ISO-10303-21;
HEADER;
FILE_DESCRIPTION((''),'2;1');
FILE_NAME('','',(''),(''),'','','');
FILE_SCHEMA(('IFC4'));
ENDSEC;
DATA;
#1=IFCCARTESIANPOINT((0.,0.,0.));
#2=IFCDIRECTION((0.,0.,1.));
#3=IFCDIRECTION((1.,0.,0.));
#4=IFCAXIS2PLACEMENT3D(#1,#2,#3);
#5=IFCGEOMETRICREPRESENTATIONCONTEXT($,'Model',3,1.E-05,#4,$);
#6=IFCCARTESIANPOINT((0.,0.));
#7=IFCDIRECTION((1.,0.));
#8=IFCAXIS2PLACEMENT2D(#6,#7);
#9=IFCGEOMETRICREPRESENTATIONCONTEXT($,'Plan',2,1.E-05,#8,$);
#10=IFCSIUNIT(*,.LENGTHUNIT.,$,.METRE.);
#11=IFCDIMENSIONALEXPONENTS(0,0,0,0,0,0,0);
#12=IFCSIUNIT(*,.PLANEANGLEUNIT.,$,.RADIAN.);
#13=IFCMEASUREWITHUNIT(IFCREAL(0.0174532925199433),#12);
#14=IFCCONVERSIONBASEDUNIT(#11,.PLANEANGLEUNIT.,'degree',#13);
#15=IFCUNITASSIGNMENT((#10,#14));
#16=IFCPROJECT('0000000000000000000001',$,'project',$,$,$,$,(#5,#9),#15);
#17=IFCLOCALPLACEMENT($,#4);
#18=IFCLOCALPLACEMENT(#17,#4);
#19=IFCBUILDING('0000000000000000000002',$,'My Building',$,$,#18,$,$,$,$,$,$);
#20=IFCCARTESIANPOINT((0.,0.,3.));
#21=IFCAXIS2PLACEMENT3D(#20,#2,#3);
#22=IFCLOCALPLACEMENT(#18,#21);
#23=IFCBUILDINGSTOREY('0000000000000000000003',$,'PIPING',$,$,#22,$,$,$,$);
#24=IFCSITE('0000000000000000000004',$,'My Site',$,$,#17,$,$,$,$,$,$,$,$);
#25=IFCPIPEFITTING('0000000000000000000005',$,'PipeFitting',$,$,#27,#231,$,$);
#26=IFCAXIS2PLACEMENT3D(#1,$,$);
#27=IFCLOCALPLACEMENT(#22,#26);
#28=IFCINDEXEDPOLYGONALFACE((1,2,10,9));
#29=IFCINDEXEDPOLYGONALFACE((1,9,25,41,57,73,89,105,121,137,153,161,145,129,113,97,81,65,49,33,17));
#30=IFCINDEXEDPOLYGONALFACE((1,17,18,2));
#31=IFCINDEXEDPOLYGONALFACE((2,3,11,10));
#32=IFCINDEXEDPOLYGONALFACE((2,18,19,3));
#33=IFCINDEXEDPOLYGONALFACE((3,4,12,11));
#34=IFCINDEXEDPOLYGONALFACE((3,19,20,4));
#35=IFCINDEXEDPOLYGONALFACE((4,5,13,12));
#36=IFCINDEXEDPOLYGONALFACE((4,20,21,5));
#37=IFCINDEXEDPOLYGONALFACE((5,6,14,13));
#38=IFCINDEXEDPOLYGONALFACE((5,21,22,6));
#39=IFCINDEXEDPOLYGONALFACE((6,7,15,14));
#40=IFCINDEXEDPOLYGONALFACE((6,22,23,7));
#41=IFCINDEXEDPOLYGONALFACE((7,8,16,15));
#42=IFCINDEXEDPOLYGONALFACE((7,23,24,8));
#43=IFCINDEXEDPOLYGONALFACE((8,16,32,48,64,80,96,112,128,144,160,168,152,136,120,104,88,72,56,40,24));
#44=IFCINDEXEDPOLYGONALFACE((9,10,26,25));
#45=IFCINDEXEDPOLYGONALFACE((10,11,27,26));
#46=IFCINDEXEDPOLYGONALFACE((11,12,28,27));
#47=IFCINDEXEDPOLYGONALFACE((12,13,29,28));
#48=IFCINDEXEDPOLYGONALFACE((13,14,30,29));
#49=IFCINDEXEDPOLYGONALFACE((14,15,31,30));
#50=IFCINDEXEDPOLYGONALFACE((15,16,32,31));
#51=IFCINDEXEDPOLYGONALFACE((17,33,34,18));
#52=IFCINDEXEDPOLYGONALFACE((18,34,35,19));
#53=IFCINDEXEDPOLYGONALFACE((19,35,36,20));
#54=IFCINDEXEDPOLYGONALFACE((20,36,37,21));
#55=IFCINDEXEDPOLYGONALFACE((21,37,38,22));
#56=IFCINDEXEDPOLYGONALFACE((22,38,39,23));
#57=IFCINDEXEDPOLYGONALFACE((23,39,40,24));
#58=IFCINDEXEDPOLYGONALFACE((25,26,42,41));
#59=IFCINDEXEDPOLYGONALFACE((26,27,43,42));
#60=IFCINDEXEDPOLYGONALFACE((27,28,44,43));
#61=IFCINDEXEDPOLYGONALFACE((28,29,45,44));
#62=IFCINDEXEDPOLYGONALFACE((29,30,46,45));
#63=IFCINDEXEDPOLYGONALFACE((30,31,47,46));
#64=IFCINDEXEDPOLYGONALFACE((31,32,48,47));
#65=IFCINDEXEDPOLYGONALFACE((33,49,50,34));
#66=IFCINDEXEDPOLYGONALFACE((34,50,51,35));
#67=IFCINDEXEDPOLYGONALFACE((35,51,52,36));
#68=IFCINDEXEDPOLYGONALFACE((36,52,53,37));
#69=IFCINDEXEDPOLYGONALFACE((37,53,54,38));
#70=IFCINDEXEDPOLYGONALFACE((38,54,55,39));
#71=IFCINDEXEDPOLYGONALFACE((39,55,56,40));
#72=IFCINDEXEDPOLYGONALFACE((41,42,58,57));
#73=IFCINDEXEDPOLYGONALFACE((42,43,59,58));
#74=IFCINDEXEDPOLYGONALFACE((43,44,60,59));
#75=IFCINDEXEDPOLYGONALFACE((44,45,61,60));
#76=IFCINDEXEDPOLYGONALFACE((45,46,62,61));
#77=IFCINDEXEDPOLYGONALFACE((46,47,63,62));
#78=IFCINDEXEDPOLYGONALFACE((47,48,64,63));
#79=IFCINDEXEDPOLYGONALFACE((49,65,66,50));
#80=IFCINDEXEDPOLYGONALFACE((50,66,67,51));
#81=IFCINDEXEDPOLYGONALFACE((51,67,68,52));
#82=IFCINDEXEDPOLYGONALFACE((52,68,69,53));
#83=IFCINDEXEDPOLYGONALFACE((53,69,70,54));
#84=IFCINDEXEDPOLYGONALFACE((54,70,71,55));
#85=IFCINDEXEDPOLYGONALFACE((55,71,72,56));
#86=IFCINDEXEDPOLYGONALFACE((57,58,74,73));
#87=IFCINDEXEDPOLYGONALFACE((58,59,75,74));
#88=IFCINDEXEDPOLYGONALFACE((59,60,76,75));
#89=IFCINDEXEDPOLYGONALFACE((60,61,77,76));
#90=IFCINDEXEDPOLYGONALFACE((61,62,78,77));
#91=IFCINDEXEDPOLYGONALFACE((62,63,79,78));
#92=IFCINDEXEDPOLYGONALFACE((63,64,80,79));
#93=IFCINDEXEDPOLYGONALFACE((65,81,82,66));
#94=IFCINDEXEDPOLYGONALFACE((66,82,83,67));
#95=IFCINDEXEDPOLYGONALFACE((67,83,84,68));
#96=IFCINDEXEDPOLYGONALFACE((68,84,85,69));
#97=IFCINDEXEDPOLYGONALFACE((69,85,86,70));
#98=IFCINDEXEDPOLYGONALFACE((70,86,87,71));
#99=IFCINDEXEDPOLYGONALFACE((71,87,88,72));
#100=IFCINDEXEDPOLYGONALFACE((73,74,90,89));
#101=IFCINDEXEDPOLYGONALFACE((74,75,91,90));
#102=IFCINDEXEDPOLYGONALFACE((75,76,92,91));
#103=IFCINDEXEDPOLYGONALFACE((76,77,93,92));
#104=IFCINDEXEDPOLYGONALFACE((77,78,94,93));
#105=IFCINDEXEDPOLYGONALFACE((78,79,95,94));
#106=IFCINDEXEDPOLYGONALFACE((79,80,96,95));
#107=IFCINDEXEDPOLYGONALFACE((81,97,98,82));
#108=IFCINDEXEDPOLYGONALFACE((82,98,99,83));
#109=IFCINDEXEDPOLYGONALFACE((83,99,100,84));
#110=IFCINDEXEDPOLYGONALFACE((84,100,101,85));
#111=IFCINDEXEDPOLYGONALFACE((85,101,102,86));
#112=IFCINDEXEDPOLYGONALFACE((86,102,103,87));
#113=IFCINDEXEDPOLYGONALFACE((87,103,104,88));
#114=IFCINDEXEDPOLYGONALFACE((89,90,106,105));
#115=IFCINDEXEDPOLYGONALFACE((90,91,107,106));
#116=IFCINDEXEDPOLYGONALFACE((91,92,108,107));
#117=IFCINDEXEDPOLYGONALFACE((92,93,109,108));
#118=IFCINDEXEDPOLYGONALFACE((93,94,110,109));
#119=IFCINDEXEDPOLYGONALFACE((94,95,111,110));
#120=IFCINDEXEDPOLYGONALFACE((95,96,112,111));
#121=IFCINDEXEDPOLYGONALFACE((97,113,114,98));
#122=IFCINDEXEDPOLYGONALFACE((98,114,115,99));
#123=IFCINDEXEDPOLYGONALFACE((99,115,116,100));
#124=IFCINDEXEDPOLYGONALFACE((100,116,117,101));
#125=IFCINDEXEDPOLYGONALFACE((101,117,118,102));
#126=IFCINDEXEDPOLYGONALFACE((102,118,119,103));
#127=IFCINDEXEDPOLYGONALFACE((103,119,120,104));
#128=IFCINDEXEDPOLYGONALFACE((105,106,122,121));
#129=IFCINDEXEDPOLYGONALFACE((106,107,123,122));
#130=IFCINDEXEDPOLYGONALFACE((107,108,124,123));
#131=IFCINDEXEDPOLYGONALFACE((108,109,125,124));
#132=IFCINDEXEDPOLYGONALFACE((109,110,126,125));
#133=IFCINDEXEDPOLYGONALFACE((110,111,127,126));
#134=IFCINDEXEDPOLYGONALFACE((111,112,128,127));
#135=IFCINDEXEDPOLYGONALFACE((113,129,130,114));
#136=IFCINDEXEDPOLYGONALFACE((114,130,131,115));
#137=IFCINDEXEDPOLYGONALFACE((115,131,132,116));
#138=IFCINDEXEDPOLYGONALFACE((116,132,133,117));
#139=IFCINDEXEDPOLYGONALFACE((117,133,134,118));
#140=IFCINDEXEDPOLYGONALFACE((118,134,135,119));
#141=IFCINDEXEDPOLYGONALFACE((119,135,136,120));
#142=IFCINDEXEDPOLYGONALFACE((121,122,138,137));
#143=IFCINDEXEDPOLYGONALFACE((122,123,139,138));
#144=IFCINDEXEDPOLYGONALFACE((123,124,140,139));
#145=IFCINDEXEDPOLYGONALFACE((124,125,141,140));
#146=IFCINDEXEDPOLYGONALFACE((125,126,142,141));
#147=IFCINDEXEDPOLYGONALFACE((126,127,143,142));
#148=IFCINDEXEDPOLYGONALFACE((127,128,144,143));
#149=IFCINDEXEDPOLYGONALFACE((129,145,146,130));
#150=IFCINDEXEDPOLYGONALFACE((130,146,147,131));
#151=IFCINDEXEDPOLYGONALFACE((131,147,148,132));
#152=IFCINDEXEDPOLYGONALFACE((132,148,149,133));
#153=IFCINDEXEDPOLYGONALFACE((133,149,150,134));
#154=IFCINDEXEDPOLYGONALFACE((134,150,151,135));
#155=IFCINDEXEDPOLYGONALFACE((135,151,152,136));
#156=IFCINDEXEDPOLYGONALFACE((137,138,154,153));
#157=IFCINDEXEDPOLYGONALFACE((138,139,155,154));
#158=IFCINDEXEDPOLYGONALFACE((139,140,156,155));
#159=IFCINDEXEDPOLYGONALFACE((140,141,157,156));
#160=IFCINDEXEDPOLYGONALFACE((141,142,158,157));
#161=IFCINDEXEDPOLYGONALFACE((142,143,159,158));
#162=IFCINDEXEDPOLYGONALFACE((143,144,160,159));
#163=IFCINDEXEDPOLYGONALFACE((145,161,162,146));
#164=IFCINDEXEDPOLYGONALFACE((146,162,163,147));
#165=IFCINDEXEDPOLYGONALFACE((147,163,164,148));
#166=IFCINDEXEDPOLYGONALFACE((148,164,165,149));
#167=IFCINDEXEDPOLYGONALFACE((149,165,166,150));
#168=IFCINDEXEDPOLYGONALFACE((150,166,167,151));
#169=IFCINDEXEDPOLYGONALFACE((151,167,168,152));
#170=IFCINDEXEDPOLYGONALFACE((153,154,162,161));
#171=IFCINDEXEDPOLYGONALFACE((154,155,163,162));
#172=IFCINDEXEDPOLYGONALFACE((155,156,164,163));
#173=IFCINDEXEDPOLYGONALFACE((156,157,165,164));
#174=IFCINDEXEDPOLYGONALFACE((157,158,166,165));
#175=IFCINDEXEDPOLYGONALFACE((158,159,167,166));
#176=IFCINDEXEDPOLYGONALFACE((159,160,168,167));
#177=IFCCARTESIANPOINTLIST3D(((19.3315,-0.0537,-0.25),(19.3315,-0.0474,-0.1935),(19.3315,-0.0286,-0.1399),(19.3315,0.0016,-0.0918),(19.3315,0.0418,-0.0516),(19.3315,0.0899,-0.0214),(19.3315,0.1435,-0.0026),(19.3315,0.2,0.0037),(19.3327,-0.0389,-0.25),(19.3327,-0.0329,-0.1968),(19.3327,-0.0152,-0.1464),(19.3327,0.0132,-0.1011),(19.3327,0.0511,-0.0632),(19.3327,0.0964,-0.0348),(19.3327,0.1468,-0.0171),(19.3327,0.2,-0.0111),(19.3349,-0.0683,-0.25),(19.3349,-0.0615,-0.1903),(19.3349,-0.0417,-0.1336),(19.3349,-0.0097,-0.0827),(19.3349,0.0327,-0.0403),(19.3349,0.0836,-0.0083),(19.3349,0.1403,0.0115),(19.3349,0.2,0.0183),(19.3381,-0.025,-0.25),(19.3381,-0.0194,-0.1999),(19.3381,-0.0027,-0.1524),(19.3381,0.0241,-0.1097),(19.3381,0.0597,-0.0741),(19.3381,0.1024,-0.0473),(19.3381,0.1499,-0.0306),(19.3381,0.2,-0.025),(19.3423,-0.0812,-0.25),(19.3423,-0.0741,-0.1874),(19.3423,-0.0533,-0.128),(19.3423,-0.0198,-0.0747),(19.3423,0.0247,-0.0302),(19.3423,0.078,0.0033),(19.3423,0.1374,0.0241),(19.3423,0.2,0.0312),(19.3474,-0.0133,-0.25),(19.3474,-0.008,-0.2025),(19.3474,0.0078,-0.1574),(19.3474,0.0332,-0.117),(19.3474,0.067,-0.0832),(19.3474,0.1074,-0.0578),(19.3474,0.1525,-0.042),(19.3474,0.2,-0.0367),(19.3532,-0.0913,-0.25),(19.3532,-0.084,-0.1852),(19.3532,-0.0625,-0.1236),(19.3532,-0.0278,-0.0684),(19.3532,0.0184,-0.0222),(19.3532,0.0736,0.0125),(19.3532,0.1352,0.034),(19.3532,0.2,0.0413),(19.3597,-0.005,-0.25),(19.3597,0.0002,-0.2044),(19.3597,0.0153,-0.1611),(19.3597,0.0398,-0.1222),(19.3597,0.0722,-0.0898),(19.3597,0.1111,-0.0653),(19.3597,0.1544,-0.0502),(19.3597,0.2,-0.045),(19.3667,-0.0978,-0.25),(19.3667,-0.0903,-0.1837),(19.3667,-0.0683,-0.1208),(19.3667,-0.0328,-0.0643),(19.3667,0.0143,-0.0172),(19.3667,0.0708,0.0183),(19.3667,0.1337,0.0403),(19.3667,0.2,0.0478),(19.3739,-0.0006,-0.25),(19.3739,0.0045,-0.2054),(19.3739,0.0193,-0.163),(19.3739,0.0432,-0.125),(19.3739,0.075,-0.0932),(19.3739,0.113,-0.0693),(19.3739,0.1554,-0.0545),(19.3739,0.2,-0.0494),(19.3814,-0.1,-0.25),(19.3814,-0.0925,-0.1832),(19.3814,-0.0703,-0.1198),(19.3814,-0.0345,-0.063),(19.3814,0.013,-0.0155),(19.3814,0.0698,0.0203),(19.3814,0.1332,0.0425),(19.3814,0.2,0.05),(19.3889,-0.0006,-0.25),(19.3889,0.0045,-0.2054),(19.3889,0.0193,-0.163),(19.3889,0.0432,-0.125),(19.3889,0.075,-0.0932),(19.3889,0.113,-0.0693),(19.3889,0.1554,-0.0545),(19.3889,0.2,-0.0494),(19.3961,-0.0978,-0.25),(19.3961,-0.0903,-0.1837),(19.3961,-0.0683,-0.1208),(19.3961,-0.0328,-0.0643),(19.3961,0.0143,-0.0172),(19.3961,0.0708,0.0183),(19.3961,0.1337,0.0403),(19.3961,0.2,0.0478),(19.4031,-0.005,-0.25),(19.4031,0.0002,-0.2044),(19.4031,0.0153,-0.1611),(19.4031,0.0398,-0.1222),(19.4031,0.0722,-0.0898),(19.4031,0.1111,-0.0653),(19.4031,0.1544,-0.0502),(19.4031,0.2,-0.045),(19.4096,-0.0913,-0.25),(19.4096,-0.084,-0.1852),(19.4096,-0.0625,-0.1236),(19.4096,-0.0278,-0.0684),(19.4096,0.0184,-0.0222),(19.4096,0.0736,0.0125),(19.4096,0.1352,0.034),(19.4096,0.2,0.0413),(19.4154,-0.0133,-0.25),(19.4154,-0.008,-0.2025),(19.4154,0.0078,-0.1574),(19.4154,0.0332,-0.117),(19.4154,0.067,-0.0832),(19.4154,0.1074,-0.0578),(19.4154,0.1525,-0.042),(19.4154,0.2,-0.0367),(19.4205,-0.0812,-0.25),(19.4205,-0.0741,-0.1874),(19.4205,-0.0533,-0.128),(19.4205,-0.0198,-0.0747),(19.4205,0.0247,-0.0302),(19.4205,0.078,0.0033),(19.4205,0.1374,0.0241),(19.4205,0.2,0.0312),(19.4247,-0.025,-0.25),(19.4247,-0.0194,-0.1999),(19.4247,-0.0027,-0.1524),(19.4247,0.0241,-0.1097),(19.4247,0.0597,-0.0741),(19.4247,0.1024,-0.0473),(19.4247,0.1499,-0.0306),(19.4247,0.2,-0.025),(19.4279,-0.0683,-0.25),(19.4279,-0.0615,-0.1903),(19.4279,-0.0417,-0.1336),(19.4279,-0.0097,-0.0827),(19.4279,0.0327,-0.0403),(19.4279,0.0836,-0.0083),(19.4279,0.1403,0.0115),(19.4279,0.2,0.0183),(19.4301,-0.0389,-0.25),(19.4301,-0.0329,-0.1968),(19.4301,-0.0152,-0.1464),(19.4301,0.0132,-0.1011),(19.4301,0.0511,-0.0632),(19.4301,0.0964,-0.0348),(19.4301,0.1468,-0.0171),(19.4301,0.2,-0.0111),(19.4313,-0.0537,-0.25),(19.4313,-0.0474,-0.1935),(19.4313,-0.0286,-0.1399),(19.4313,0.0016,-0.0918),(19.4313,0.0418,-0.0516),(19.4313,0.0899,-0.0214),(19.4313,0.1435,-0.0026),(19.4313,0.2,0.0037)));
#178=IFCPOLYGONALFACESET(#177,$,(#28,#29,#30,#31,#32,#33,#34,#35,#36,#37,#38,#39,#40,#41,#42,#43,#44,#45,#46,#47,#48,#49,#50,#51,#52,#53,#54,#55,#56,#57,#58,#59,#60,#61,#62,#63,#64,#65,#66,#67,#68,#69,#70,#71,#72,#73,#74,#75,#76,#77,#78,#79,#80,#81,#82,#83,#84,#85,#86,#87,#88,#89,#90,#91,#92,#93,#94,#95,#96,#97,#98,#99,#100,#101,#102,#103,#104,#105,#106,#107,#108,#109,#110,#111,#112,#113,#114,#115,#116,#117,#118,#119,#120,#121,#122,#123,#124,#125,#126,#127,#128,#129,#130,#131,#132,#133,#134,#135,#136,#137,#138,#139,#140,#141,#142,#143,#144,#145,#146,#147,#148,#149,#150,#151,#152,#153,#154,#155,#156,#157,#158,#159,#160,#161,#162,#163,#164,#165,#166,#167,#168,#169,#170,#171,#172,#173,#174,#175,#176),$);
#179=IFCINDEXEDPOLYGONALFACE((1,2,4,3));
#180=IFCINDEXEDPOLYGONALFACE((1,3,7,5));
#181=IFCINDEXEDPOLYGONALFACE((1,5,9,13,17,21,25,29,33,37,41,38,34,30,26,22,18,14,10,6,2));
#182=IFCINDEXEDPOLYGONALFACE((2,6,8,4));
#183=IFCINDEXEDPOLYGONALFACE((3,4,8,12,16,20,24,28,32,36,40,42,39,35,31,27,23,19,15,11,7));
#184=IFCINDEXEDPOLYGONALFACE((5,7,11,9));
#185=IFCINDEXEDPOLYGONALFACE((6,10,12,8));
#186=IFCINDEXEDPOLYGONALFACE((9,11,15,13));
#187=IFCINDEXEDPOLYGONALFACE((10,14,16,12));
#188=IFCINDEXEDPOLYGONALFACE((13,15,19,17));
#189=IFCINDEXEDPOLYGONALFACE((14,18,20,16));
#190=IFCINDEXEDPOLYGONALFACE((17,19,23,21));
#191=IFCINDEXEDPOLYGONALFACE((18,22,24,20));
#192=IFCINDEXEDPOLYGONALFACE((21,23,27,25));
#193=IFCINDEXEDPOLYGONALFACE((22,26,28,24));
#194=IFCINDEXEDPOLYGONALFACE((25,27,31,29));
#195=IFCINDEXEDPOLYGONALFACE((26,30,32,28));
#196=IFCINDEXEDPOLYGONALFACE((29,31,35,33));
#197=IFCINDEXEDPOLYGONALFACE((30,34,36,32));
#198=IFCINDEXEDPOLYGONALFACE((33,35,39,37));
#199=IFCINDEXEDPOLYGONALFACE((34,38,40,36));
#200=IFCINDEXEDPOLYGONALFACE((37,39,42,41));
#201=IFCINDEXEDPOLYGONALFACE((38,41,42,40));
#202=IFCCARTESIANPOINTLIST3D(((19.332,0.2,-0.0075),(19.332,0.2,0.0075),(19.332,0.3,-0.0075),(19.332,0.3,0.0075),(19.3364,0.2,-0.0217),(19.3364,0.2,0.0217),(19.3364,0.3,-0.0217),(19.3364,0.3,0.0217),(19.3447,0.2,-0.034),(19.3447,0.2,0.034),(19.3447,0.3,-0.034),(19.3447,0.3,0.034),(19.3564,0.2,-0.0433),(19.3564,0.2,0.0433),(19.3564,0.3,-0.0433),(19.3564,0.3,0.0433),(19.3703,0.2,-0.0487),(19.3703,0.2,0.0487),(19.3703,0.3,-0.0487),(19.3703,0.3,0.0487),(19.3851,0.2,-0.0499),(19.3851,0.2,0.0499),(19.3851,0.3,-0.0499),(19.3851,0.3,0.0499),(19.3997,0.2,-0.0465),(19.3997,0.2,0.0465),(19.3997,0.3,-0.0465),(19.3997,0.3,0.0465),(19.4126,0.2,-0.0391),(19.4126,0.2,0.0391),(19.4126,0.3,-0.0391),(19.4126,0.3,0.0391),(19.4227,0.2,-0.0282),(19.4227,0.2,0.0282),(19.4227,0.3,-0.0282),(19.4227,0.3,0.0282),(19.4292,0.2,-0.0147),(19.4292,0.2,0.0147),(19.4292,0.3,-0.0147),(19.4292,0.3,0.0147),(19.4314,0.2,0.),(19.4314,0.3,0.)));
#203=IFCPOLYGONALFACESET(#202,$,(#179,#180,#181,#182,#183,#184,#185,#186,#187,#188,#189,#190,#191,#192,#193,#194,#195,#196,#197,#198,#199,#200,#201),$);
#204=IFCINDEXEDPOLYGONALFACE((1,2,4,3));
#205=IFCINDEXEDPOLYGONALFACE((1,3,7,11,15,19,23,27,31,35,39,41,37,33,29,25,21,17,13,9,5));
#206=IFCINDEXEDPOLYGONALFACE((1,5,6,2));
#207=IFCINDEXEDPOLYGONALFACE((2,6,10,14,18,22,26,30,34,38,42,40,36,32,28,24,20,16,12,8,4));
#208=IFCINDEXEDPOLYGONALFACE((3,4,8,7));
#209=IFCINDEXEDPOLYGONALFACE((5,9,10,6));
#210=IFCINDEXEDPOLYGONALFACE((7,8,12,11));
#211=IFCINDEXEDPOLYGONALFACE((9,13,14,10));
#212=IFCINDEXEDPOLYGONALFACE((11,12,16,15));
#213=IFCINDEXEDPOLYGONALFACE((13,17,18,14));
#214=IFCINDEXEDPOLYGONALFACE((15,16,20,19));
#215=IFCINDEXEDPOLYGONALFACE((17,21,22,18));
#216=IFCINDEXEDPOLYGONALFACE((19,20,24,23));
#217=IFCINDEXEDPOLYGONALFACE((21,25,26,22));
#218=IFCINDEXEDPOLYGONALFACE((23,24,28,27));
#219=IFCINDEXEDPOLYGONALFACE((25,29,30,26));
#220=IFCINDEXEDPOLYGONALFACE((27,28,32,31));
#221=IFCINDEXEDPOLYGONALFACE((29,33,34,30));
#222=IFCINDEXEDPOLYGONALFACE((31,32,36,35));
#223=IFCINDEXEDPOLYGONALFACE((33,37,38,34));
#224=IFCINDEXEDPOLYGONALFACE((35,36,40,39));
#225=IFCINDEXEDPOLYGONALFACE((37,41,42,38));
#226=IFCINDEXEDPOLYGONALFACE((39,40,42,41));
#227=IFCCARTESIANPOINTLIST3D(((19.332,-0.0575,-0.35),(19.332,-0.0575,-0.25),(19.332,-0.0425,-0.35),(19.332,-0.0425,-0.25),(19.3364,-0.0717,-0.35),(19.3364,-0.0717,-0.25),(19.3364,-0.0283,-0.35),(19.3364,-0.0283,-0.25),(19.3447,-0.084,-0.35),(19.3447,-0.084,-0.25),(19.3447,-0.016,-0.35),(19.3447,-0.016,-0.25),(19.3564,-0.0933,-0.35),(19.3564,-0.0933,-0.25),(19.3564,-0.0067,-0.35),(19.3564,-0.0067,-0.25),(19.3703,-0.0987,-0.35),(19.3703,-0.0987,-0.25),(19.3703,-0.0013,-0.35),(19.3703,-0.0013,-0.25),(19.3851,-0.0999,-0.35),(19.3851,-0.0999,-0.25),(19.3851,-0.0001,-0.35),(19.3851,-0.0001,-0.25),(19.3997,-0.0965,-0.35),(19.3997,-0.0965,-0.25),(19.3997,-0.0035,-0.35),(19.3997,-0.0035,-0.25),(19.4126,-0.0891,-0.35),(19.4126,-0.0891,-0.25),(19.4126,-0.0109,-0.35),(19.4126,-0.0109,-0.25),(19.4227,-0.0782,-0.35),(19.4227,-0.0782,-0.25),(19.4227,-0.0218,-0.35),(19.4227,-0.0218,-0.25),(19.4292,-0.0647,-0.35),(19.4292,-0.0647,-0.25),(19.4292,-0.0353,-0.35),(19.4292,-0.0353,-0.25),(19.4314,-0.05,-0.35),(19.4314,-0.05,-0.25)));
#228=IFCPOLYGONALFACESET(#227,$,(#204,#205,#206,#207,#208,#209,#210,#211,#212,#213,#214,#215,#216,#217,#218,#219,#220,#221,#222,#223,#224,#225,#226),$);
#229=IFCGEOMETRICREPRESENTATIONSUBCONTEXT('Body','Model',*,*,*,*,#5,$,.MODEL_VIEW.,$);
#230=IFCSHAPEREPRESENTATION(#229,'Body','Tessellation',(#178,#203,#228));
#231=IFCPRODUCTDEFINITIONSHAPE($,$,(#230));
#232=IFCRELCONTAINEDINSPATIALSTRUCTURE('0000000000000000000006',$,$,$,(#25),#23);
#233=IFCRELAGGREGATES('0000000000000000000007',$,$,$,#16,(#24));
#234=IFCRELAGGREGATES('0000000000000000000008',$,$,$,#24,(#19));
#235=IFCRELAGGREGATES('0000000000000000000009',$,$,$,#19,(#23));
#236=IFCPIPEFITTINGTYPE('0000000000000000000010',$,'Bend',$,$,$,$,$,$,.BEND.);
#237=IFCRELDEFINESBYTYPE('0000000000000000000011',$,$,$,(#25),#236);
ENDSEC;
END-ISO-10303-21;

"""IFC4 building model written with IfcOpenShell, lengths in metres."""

from ifc_helpers import new_model, entity, si_unit, converted_unit, frame, origin_with_axes, origin_2d_with_axis, place, context, subcontext, project, spatial, circle, extrude, source, transform, mapped, type_object, type_shapes, element, save


model = new_model("IFC4")

# Units and contexts
model_context = context("Model", 3, precision=1e-05, world=origin_with_axes())
plan_context = context("Plan", 2, precision=1e-05, world=origin_2d_with_axis())
body_context = subcontext(model_context, "Body", "Model", "MODEL_VIEW")
ifc_project = project(units=[si_unit("LENGTHUNIT", "METRE"), converted_unit("PLANEANGLEUNIT", "degree", entity("IfcReal", 0.0174532925199433), si_unit("PLANEANGLEUNIT", "RADIAN"), dimensions=[0, 0, 0, 0, 0, 0, 0])], contexts=[model_context, plan_context])

# Site, building, storey
site_placement = place(None, origin_with_axes())
site = spatial("IfcSite", under=ifc_project, at=site_placement, Name="My Site")
building_placement = place(site_placement, origin_with_axes())
building = spatial("IfcBuilding", under=site, at=building_placement, Name="My Building")
storey_placement = place(building_placement, frame((0.0, 0.0, 3.0), z_axis=(0.0, 0.0, 1.0), x_axis=(1.0, 0.0, 0.0)))
storey = spatial("IfcBuildingStorey", under=building, at=storey_placement, Name="PIPING")

# Shared definitions
pipe_fitting_type = type_object("IfcPipeFittingType", Name="Bend", PredefinedType="BEND")
shared_shape = source(origin_with_axes(), body_context, "Body", "SolidModel", [
    entity("IfcSweptDiskSolid", entity("IfcIndexedPolyCurve", entity("IfcCartesianPointList3D", [[0.0, 0.0, -0.1], [0.0, 0.0732, -0.2768], [0.0, 0.25, -0.35]]), [entity("IfcArcIndex", [1, 2, 3])]), 0.05),
    extrude(circle(Radius=0.05), origin_with_axes(), (0.0, 0.0, -1.0), 0.1),
    extrude(circle(Radius=0.05), frame((0.0, 0.25, -0.35), z_axis=(0.0, 1.0, 0.0), x_axis=(1.0, 0.0, 0.0)), (0.0, 0.0, 1.0), 0.1),
])
type_shapes(pipe_fitting_type, [shared_shape])

# Pipe fitting
for number, where, z_axis, x_axis, name in (
    (1, (19.3814, 0.3, 0.0), (0.0, 1.0, 0.0), (1.0, 0.0, 0.0), "PipeFitting"),
):
    element("IfcPipeFitting", number, at=place(storey_placement, frame(where, z_axis=z_axis, x_axis=x_axis)), inside=storey, type_object=pipe_fitting_type, Name=name, context=body_context, shape_type="MappedRepresentation", body=[
        mapped(shared_shape, transform((0.0, 0.0, 0.0), x_axis=(1.0, 0.0, 0.0), y_axis=(0.0, 1.0, 0.0), z_axis=(0.0, 0.0, 1.0), scale=1.0)),
    ])

save(model, "model.ifc")
